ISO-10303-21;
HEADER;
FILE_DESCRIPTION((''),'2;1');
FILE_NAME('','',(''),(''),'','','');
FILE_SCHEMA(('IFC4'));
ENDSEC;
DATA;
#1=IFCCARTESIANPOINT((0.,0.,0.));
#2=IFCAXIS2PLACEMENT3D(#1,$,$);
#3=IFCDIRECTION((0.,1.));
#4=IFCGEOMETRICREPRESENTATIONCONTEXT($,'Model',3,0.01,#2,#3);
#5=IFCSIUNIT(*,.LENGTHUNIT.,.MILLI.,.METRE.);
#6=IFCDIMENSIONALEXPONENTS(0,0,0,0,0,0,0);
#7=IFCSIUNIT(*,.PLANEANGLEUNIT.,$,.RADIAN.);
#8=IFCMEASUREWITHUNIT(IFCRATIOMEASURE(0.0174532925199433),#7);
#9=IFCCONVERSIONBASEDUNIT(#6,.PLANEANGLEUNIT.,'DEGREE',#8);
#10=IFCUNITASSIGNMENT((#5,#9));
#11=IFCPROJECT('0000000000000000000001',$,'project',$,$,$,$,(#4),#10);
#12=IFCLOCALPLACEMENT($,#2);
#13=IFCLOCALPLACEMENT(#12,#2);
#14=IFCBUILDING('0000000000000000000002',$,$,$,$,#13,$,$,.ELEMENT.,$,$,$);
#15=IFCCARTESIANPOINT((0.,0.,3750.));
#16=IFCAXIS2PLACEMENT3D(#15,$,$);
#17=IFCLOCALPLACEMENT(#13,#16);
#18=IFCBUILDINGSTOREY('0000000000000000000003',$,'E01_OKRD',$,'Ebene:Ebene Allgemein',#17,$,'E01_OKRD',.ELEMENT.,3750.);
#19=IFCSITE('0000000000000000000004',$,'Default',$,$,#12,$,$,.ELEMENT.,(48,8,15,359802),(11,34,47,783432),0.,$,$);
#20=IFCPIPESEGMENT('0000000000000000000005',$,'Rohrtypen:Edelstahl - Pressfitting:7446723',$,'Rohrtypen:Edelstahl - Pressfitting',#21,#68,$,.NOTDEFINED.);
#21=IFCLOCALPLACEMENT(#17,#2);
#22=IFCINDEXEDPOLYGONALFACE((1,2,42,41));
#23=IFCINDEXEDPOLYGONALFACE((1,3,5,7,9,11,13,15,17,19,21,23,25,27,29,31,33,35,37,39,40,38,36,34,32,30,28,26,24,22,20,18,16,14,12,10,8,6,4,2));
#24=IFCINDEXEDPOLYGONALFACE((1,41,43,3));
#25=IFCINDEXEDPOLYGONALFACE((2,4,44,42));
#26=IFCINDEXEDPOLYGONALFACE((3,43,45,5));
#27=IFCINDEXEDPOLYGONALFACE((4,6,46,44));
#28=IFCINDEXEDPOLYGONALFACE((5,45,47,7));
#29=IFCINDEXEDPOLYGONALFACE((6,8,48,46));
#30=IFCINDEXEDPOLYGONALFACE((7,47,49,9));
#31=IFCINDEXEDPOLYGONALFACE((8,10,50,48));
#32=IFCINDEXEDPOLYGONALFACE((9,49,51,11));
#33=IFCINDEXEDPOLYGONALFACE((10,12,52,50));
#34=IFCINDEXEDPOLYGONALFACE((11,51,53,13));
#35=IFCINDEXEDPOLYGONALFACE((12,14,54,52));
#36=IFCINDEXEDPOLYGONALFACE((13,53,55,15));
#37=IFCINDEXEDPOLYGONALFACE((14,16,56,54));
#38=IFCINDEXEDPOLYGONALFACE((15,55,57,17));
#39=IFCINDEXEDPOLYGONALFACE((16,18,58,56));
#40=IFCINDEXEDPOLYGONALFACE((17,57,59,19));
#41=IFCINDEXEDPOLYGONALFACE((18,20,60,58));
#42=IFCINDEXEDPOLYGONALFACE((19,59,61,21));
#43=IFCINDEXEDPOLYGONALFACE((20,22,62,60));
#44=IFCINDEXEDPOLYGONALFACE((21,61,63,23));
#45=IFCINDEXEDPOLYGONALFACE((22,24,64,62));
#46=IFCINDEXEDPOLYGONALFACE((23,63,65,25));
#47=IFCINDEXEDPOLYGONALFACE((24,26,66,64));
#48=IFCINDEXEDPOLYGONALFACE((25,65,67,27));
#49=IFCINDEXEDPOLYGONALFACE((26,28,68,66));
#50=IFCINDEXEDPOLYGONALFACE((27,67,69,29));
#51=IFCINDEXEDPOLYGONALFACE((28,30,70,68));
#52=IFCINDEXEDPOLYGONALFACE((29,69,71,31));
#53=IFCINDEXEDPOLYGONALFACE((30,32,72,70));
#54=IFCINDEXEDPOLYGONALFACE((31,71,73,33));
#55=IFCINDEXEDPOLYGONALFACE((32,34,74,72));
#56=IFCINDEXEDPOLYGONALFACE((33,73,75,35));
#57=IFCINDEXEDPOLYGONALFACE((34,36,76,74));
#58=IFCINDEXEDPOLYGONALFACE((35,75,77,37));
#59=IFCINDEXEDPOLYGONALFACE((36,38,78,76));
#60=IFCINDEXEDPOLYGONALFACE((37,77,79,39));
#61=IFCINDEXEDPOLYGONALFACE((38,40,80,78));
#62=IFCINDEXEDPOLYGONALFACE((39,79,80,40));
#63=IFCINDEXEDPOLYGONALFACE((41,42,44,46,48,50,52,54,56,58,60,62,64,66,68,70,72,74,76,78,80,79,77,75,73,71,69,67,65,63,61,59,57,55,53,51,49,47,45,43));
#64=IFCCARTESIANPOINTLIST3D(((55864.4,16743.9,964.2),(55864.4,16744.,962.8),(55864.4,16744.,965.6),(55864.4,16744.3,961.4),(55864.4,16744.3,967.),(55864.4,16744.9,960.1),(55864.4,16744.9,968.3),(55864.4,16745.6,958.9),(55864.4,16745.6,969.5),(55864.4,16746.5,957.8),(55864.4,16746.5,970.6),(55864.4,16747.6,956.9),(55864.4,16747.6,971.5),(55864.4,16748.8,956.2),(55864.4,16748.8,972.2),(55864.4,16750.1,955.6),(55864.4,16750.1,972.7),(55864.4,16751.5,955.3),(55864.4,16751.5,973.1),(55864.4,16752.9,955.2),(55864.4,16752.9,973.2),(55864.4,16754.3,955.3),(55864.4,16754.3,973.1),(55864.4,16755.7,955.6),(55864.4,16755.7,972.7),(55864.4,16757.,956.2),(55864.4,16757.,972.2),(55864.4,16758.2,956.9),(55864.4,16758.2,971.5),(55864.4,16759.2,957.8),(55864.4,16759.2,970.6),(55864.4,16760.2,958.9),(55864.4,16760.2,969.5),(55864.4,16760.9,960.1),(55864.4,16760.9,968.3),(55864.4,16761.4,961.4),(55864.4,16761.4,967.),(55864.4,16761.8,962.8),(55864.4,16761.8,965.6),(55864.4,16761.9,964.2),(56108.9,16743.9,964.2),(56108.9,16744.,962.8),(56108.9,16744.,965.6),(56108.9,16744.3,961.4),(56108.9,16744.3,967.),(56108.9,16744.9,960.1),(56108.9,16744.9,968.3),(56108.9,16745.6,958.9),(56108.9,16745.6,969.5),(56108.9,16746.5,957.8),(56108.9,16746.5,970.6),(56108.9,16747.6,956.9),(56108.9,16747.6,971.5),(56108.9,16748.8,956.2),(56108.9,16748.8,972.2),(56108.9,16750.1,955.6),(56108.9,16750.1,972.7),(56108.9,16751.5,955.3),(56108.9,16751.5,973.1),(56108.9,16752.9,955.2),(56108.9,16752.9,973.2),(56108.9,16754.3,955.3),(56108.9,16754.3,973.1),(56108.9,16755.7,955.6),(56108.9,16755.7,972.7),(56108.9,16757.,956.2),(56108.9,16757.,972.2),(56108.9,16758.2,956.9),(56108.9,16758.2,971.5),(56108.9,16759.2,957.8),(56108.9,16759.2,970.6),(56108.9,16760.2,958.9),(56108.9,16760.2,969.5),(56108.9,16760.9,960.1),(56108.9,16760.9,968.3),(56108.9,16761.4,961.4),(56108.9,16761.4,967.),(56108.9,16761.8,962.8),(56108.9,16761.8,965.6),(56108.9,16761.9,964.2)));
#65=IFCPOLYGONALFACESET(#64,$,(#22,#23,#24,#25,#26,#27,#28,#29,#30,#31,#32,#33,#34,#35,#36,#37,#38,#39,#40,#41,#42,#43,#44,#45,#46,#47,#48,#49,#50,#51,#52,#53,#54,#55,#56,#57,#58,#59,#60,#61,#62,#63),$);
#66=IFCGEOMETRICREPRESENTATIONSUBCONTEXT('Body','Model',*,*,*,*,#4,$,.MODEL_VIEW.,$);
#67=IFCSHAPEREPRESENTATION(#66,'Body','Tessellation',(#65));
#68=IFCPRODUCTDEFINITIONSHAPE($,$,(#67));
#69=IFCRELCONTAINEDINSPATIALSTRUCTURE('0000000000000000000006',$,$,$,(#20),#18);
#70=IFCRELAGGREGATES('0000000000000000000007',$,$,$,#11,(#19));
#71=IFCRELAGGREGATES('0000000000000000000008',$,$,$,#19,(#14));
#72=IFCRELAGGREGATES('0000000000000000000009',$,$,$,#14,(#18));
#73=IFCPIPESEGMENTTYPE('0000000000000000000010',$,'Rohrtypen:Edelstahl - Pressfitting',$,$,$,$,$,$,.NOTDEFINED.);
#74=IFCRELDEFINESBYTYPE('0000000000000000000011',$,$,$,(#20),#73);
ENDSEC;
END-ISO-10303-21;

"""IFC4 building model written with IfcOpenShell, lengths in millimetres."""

from ifc_helpers import new_model, entity, si_unit, converted_unit, direction, frame, origin, place, context, subcontext, project, spatial, indexed_curve, outline, extrude, type_object, element, save


model = new_model("IFC4")

# Units and contexts
model_context = context("Model", 3, precision=0.01, world=origin(), true_north=direction((0.0, 1.0)))
body_context = subcontext(model_context, "Body", "Model", "MODEL_VIEW")
ifc_project = project(units=[si_unit("LENGTHUNIT", "METRE", prefix="MILLI"), converted_unit("PLANEANGLEUNIT", "DEGREE", entity("IfcRatioMeasure", 0.0174532925199433), si_unit("PLANEANGLEUNIT", "RADIAN"), dimensions=[0, 0, 0, 0, 0, 0, 0])], contexts=[model_context])

# Site, building, storey
site_placement = place(None, origin())
site = spatial("IfcSite", under=ifc_project, at=site_placement, Name="Default", CompositionType="ELEMENT", RefLatitude=(48, 8, 15, 359802), RefLongitude=(11, 34, 47, 783432), RefElevation=0.0)
building_placement = place(site_placement, origin())
building = spatial("IfcBuilding", under=site, at=building_placement, CompositionType="ELEMENT")
storey_placement = place(building_placement, frame((0.0, 0.0, 3750.0)))
storey = spatial("IfcBuildingStorey", under=building, at=storey_placement, Name="E01_OKRD", ObjectType="Ebene:Ebene Allgemein", LongName="E01_OKRD", CompositionType="ELEMENT", Elevation=3750.0)

# Pipe segment
pipe_segment_type_1 = type_object("IfcPipeSegmentType", Name="Rohrtypen:Edelstahl - Pressfitting", PredefinedType="NOTDEFINED")
pipe_segment_1_placement = place(storey_placement, origin())
element("IfcPipeSegment", 1, at=pipe_segment_1_placement, inside=storey, type_object=pipe_segment_type_1, Name="Rohrtypen:Edelstahl - Pressfitting:7446723", ObjectType="Rohrtypen:Edelstahl - Pressfitting", PredefinedType="NOTDEFINED", context=body_context, shape_type="SweptSolid", body=[
    extrude(outline(indexed_curve([(9.0, 0.0), (8.9, 1.4), (8.6, 2.8), (8.0, 4.1), (7.3, 5.3), (6.4, 6.4), (5.3, 7.3), (4.1, 8.0), (2.8, 8.6), (1.4, 8.9), (0.0, 9.0), (-1.4, 8.9), (-2.8, 8.6), (-4.1, 8.0), (-5.3, 7.3), (-6.4, 6.4), (-7.3, 5.3), (-8.0, 4.1), (-8.6, 2.8), (-8.9, 1.4), (-9.0, 0.0), (-8.9, -1.4), (-8.6, -2.8), (-8.0, -4.1), (-7.3, -5.3), (-6.4, -6.4), (-5.3, -7.3), (-4.1, -8.0), (-2.8, -8.6), (-1.4, -8.9), (0.0, -9.0), (1.4, -8.9), (2.8, -8.6), (4.1, -8.0), (5.3, -7.3), (6.4, -6.4), (7.3, -5.3), (8.0, -4.1), (8.6, -2.8), (8.9, -1.4), (9.0, 0.0)], self_intersect=False)), frame((55864.4, 16752.9, 964.2), z_axis=(1.0, 0.0, 0.0), x_axis=(0.0, -1.0, 0.0)), (0.0, 0.0, 1.0), 244.5),
])

save(model, "model.ifc")
